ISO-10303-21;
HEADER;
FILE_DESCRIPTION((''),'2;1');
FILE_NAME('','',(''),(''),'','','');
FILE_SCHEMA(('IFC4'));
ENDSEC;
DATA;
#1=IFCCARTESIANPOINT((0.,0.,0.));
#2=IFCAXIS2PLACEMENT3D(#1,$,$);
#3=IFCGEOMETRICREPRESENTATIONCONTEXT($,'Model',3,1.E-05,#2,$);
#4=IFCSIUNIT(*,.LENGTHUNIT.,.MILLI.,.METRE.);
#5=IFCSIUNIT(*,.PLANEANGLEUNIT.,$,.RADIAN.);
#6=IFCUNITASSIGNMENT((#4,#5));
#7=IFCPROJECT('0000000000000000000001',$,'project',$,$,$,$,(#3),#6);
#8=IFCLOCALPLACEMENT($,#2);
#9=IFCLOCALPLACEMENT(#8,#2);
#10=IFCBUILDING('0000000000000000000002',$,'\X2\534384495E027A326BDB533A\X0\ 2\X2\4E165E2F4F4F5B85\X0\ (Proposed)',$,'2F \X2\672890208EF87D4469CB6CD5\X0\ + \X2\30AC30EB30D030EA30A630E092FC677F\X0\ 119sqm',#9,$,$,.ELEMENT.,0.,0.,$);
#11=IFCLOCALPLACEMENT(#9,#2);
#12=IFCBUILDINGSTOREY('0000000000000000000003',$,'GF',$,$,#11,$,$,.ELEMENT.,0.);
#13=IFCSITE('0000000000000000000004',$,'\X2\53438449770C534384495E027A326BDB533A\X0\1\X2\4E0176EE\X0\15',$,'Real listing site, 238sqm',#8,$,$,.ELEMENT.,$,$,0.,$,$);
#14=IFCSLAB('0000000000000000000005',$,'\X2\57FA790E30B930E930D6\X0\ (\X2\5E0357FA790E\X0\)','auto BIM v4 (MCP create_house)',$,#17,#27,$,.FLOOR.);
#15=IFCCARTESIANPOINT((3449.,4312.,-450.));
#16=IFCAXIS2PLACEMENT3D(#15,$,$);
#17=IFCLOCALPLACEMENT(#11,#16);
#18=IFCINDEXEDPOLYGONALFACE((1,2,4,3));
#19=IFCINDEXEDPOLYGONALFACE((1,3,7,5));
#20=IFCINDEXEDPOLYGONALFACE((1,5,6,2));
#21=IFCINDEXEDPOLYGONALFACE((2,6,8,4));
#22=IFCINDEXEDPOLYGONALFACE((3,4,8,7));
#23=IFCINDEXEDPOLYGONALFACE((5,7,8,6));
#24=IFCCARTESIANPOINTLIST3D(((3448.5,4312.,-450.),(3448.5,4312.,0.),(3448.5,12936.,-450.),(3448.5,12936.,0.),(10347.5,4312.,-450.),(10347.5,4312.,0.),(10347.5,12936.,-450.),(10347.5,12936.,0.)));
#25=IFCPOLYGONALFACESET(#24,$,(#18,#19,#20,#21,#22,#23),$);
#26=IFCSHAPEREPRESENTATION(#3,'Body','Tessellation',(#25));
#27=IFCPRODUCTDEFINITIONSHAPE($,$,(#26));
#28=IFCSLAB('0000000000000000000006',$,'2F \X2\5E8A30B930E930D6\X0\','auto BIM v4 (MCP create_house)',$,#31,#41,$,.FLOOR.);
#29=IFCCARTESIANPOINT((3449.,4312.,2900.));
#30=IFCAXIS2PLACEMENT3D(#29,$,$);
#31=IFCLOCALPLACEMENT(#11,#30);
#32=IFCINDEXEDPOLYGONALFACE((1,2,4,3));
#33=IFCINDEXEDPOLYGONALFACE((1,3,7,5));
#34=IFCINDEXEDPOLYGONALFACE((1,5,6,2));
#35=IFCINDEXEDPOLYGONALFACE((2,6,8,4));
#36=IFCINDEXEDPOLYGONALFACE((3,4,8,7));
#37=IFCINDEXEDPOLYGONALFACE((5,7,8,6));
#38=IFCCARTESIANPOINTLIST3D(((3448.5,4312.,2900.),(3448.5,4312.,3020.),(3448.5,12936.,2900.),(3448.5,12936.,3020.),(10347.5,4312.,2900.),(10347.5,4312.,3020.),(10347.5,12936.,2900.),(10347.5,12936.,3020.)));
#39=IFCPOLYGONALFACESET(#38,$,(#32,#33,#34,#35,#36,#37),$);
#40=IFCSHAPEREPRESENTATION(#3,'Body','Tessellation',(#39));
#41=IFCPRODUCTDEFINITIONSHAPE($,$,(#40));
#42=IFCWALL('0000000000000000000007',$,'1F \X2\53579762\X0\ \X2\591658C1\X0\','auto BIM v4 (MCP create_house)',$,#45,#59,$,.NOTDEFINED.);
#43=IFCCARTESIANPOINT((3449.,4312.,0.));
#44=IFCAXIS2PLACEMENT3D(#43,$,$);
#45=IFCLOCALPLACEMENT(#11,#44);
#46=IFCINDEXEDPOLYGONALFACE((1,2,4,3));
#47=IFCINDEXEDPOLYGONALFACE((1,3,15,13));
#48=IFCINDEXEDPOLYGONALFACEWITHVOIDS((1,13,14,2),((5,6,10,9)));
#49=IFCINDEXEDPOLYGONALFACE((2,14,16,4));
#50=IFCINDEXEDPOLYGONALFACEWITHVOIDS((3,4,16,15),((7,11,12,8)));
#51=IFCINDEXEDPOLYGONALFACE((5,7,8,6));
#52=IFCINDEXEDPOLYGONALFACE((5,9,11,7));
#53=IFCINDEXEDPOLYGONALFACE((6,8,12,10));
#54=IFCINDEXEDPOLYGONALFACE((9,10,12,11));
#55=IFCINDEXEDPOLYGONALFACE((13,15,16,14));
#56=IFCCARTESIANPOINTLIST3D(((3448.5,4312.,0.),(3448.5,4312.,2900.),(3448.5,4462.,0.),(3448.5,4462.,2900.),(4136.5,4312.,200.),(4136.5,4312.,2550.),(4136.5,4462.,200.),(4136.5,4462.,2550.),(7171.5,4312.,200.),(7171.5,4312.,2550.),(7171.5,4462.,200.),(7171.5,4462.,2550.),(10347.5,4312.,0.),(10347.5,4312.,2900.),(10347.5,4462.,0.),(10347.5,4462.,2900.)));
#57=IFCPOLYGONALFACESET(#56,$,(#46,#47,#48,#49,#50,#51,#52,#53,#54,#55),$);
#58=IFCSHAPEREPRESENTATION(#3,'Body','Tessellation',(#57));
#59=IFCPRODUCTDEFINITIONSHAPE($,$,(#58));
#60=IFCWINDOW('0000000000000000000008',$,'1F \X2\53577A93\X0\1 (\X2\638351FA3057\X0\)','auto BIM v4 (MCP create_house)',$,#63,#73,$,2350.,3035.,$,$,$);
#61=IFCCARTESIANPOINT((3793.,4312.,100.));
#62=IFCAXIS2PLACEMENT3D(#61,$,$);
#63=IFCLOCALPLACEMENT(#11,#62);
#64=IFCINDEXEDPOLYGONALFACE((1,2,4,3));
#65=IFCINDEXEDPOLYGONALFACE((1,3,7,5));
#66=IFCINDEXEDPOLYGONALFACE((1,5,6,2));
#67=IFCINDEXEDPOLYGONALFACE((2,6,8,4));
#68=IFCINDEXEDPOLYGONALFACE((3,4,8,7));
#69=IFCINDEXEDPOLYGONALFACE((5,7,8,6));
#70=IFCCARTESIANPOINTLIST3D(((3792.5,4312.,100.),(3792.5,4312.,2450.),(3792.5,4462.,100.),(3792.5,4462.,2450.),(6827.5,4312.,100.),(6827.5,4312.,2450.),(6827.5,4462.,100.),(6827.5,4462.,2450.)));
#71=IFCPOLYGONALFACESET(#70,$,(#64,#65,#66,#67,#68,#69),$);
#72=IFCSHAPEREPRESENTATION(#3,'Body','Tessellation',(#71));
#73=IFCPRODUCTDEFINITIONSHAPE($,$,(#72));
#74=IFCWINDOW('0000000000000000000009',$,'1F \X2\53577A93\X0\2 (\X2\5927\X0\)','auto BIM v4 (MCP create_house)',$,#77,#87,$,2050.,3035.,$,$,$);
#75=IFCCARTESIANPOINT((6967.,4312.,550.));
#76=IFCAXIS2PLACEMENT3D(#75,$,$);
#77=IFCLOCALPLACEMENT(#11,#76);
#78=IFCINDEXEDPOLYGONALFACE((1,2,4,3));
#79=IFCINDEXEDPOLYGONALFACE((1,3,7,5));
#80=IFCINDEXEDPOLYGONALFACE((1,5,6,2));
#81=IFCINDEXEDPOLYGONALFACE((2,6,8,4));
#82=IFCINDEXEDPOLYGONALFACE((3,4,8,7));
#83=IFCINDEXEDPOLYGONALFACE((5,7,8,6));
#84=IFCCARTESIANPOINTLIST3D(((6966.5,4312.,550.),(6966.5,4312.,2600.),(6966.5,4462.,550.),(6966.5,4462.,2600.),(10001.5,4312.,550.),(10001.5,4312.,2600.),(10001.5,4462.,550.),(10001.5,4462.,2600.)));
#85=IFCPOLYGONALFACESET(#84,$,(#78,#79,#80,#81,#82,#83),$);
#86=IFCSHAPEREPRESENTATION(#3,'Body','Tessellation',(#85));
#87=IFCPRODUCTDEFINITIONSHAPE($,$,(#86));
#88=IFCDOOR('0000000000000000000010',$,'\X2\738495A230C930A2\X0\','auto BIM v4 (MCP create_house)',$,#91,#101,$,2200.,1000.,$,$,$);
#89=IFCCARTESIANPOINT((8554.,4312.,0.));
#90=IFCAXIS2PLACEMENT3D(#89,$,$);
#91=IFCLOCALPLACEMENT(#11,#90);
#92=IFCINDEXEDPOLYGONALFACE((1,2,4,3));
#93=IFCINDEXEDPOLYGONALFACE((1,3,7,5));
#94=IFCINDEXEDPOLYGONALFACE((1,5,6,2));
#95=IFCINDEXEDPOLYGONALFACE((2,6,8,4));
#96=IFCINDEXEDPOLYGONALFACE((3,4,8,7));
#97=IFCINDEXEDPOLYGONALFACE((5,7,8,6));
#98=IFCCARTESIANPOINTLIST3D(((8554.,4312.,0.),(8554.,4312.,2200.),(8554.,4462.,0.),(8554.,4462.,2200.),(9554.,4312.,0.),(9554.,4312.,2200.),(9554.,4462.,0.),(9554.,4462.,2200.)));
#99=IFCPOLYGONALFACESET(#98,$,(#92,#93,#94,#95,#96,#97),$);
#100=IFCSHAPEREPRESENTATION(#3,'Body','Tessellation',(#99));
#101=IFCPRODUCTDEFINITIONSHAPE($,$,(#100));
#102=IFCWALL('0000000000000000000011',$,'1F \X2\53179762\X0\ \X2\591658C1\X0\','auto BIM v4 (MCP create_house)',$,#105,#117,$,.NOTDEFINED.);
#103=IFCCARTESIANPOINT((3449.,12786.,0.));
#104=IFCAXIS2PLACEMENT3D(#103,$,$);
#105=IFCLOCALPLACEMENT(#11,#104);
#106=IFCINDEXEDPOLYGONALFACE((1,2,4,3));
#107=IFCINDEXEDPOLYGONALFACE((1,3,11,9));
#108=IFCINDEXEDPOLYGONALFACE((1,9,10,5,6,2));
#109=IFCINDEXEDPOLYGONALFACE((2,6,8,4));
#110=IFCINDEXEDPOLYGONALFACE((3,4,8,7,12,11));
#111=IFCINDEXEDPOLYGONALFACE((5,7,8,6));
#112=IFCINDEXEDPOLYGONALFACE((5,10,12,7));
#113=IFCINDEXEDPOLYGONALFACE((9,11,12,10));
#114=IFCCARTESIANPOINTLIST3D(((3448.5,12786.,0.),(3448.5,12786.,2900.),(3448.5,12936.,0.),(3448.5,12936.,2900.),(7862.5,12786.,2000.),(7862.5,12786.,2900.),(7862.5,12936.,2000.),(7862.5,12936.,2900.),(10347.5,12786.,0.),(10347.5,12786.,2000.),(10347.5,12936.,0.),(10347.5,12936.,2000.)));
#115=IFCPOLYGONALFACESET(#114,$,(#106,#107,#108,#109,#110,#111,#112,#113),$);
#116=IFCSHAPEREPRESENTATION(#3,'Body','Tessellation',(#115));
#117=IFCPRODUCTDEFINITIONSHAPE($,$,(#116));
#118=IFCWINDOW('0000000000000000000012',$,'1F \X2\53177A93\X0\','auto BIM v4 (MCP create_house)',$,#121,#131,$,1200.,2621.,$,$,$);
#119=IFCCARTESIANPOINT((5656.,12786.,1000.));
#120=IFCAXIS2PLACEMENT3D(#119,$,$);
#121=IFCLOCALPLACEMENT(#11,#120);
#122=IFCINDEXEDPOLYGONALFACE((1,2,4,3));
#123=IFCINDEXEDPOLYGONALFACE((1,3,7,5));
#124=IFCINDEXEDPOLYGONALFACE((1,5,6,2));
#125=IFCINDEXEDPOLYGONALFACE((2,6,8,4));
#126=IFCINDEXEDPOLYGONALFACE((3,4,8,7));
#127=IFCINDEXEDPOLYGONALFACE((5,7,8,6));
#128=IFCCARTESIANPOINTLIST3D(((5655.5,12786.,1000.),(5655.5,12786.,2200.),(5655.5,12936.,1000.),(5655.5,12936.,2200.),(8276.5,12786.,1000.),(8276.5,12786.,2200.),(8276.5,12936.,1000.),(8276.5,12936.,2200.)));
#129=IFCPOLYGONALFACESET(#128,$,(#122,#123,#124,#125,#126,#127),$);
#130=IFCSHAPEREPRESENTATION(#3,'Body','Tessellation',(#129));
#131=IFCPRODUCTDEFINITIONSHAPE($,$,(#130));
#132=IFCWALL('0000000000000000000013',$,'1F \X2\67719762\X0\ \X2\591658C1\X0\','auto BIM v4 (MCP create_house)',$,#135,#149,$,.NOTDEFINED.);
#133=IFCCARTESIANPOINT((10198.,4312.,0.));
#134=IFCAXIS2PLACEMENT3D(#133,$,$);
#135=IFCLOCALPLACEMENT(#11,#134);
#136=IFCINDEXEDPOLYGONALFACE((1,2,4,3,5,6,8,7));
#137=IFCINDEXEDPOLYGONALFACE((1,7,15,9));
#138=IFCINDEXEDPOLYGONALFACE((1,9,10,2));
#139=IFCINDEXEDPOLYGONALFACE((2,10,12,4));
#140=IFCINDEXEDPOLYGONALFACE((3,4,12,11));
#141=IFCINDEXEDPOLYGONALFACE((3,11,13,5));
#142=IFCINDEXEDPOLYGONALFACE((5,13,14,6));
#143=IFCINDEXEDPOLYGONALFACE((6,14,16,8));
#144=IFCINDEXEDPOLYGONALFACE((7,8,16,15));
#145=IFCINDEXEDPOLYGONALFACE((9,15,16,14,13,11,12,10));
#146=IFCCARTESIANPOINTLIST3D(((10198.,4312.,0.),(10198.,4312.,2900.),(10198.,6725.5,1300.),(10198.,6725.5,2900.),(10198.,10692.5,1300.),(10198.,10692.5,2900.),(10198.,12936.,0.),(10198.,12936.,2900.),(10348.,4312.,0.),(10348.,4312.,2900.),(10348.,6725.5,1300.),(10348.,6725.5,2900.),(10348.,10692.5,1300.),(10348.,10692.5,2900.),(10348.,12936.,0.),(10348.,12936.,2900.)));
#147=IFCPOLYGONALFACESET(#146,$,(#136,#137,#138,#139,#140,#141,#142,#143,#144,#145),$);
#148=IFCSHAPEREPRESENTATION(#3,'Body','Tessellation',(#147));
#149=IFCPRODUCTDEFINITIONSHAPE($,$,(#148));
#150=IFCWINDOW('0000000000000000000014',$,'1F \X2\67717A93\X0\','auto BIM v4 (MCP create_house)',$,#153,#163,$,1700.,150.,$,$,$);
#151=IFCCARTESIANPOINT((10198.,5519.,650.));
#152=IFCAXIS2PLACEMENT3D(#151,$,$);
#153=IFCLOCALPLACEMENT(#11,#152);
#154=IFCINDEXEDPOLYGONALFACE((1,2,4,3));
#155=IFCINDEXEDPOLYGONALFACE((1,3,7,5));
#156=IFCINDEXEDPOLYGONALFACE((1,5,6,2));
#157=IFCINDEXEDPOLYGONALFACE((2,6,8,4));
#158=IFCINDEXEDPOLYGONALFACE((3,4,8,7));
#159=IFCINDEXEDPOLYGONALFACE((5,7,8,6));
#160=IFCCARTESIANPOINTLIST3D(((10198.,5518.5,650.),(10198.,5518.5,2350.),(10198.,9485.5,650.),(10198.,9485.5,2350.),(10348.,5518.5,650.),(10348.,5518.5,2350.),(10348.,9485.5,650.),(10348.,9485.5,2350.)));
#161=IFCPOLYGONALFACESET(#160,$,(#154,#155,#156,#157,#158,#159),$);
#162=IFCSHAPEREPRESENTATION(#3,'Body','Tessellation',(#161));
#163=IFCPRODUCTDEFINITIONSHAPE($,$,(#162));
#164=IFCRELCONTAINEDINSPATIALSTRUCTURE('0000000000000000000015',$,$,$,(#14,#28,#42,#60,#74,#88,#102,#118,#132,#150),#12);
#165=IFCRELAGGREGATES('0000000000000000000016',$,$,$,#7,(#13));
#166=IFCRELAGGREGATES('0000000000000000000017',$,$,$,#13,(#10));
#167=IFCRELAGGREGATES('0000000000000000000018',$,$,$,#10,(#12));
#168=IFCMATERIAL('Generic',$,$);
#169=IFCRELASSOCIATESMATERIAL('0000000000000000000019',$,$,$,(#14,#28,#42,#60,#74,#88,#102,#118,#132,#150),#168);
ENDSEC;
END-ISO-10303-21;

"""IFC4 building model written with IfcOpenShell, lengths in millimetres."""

from ifc_helpers import new_model, si_unit, frame, frame_2d, origin, place, context, project, spatial, rectangle, extrude, material, element, fill, save


model = new_model("IFC4")

# Units and contexts
model_context = context("Model", 3, precision=1e-05, world=origin())
ifc_project = project(units=[si_unit("LENGTHUNIT", "METRE", prefix="MILLI"), si_unit("PLANEANGLEUNIT", "RADIAN")], contexts=[model_context])

# Site, building, storey
site_placement = place(None, origin())
site = spatial("IfcSite", under=ifc_project, at=site_placement, Name="千葉県千葉市稲毛区1丁目15", ObjectType="Real listing site, 238sqm", CompositionType="ELEMENT", RefElevation=0.0)
building_placement = place(site_placement, origin())
building = spatial("IfcBuilding", under=site, at=building_placement, Name="千葉市稲毛区 2世帯住宅 (Proposed)", ObjectType="2F 木造軸組構法 + ガルバリウム鋼板 119sqm", CompositionType="ELEMENT", ElevationOfRefHeight=0.0, ElevationOfTerrain=0.0)
storey_placement = place(building_placement, origin())
storey = spatial("IfcBuildingStorey", under=building, at=storey_placement, Name="GF", CompositionType="ELEMENT", Elevation=0.0)

# Slabs
ifc_material = material(Name="Generic")
slab_1_placement = place(storey_placement, frame((3449.0, 4312.0, -450.0)))
element("IfcSlab", 1, at=slab_1_placement, inside=storey, material=ifc_material, Name="基礎スラブ (布基礎)", Description="auto BIM v4 (MCP create_house)", PredefinedType="FLOOR", context=model_context, shape_type="SweptSolid", body=[
    extrude(rectangle(XDim=6899.0, YDim=8624.0, at=frame_2d((3449.0, 4312.0))), frame((3449.0, 4312.0, -450.0)), (0.0, 0.0, 1.0), 450.0),
])
slab_2_placement = place(storey_placement, frame((3449.0, 4312.0, 2900.0)))
element("IfcSlab", 2, at=slab_2_placement, inside=storey, material=ifc_material, Name="2F 床スラブ", Description="auto BIM v4 (MCP create_house)", PredefinedType="FLOOR", context=model_context, shape_type="SweptSolid", body=[
    extrude(rectangle(XDim=6899.0, YDim=8624.0, at=frame_2d((3449.0, 4312.0))), frame((3449.0, 4312.0, 2900.0)), (0.0, 0.0, 1.0), 120.0),
])

# Wall, openings, windows, door
wall_1_placement = place(storey_placement, frame((3449.0, 4312.0, 0.0)))
wall_1 = element("IfcWall", 3, at=wall_1_placement, inside=storey, material=ifc_material, Name="1F 南面 外壁", Description="auto BIM v4 (MCP create_house)", PredefinedType="NOTDEFINED", context=model_context, shape_type="SweptSolid", body=[
    extrude(rectangle(XDim=6899.0, YDim=150.0, at=frame_2d((3449.0, 75.0))), frame((3449.0, 4312.0, 0.0)), (0.0, 0.0, 1.0), 2900.0),
])
opening_1_placement = place(storey_placement, frame((3793.0, 4312.0, 100.0)))
opening_1 = element("IfcOpeningElement", 4, at=opening_1_placement, cuts=wall_1, PredefinedType="NOTDEFINED", context=model_context, shape_type="SweptSolid", body=[
    extrude(rectangle(XDim=3035.0, YDim=150.0, at=frame_2d((1517.0, 75.0))), frame((3793.0, 4312.0, 100.0)), (0.0, 0.0, 1.0), 2350.0),
])
opening_2_placement = place(storey_placement, frame((6967.0, 4312.0, 550.0)))
opening_2 = element("IfcOpeningElement", 5, at=opening_2_placement, cuts=wall_1, PredefinedType="NOTDEFINED", context=model_context, shape_type="SweptSolid", body=[
    extrude(rectangle(XDim=3035.0, YDim=150.0, at=frame_2d((1517.0, 75.0))), frame((6967.0, 4312.0, 550.0)), (0.0, 0.0, 1.0), 2050.0),
])
opening_3_placement = place(storey_placement, frame((8554.0, 4312.0, 0.0)))
opening_3 = element("IfcOpeningElement", 6, at=opening_3_placement, cuts=wall_1, PredefinedType="NOTDEFINED", context=model_context, shape_type="SweptSolid", body=[
    extrude(rectangle(XDim=1000.0, YDim=150.0, at=frame_2d((500.0, 75.0))), frame((8554.0, 4312.0, 0.0)), (0.0, 0.0, 1.0), 2200.0),
])
window_1_placement = place(storey_placement, frame((3793.0, 4312.0, 100.0)))
window_1 = element("IfcWindow", 7, at=window_1_placement, inside=storey, material=ifc_material, Name="1F 南窓1 (掃出し)", Description="auto BIM v4 (MCP create_house)", OverallHeight=2350.0, OverallWidth=3035.0, context=model_context, shape_type="SweptSolid", body=[
    extrude(rectangle(XDim=3035.0, YDim=150.0, at=frame_2d((1517.0, 75.0))), frame((3793.0, 4312.0, 100.0)), (0.0, 0.0, 1.0), 2350.0),
])
fill(opening_1, window_1)
window_2_placement = place(storey_placement, frame((6967.0, 4312.0, 550.0)))
window_2 = element("IfcWindow", 8, at=window_2_placement, inside=storey, material=ifc_material, Name="1F 南窓2 (大)", Description="auto BIM v4 (MCP create_house)", OverallHeight=2050.0, OverallWidth=3035.0, context=model_context, shape_type="SweptSolid", body=[
    extrude(rectangle(XDim=3035.0, YDim=150.0, at=frame_2d((1517.0, 75.0))), frame((6967.0, 4312.0, 550.0)), (0.0, 0.0, 1.0), 2050.0),
])
fill(opening_2, window_2)
door_1_placement = place(storey_placement, frame((8554.0, 4312.0, 0.0)))
door_1 = element("IfcDoor", 9, at=door_1_placement, inside=storey, material=ifc_material, Name="玄関ドア", Description="auto BIM v4 (MCP create_house)", OverallHeight=2200.0, OverallWidth=1000.0, context=model_context, shape_type="SweptSolid", body=[
    extrude(rectangle(XDim=1000.0, YDim=150.0, at=frame_2d((500.0, 75.0))), frame((8554.0, 4312.0, 0.0)), (0.0, 0.0, 1.0), 2200.0),
])
fill(opening_3, door_1)

# Walls, openings, windows
wall_2_placement = place(storey_placement, frame((3449.0, 12786.0, 0.0)))
wall_2 = element("IfcWall", 10, at=wall_2_placement, inside=storey, material=ifc_material, Name="1F 北面 外壁", Description="auto BIM v4 (MCP create_house)", PredefinedType="NOTDEFINED", context=model_context, shape_type="SweptSolid", body=[
    extrude(rectangle(XDim=6899.0, YDim=150.0, at=frame_2d((3449.0, 75.0))), frame((3449.0, 12786.0, 0.0)), (0.0, 0.0, 1.0), 2900.0),
])
opening_4_placement = place(storey_placement, frame((5656.0, 12786.0, 1000.0)))
opening_4 = element("IfcOpeningElement", 11, at=opening_4_placement, cuts=wall_2, PredefinedType="NOTDEFINED", context=model_context, shape_type="SweptSolid", body=[
    extrude(rectangle(XDim=2621.0, YDim=150.0, at=frame_2d((1310.0, 75.0))), frame((5656.0, 12786.0, 1000.0)), (0.0, 0.0, 1.0), 1200.0),
])
window_3_placement = place(storey_placement, frame((5656.0, 12786.0, 1000.0)))
window_3 = element("IfcWindow", 12, at=window_3_placement, inside=storey, material=ifc_material, Name="1F 北窓", Description="auto BIM v4 (MCP create_house)", OverallHeight=1200.0, OverallWidth=2621.0, context=model_context, shape_type="SweptSolid", body=[
    extrude(rectangle(XDim=2621.0, YDim=150.0, at=frame_2d((1310.0, 75.0))), frame((5656.0, 12786.0, 1000.0)), (0.0, 0.0, 1.0), 1200.0),
])
fill(opening_4, window_3)
wall_3_placement = place(storey_placement, frame((10198.0, 4312.0, 0.0)))
wall_3 = element("IfcWall", 13, at=wall_3_placement, inside=storey, material=ifc_material, Name="1F 東面 外壁", Description="auto BIM v4 (MCP create_house)", PredefinedType="NOTDEFINED", context=model_context, shape_type="SweptSolid", body=[
    extrude(rectangle(XDim=150.0, YDim=8624.0, at=frame_2d((75.0, 4312.0))), frame((10198.0, 4312.0, 0.0)), (0.0, 0.0, 1.0), 2900.0),
])
opening_5_placement = place(storey_placement, frame((10198.0, 5519.0, 650.0)))
opening_5 = element("IfcOpeningElement", 14, at=opening_5_placement, cuts=wall_3, PredefinedType="NOTDEFINED", context=model_context, shape_type="SweptSolid", body=[
    extrude(rectangle(XDim=150.0, YDim=3967.0, at=frame_2d((75.0, 1983.0))), frame((10198.0, 5519.0, 650.0)), (0.0, 0.0, 1.0), 1700.0),
])
window_4_placement = place(storey_placement, frame((10198.0, 5519.0, 650.0)))
window_4 = element("IfcWindow", 15, at=window_4_placement, inside=storey, material=ifc_material, Name="1F 東窓", Description="auto BIM v4 (MCP create_house)", OverallHeight=1700.0, OverallWidth=150.0, context=model_context, shape_type="SweptSolid", body=[
    extrude(rectangle(XDim=150.0, YDim=3967.0, at=frame_2d((75.0, 1983.0))), frame((10198.0, 5519.0, 650.0)), (0.0, 0.0, 1.0), 1700.0),
])
fill(opening_5, window_4)

save(model, "model.ifc")
